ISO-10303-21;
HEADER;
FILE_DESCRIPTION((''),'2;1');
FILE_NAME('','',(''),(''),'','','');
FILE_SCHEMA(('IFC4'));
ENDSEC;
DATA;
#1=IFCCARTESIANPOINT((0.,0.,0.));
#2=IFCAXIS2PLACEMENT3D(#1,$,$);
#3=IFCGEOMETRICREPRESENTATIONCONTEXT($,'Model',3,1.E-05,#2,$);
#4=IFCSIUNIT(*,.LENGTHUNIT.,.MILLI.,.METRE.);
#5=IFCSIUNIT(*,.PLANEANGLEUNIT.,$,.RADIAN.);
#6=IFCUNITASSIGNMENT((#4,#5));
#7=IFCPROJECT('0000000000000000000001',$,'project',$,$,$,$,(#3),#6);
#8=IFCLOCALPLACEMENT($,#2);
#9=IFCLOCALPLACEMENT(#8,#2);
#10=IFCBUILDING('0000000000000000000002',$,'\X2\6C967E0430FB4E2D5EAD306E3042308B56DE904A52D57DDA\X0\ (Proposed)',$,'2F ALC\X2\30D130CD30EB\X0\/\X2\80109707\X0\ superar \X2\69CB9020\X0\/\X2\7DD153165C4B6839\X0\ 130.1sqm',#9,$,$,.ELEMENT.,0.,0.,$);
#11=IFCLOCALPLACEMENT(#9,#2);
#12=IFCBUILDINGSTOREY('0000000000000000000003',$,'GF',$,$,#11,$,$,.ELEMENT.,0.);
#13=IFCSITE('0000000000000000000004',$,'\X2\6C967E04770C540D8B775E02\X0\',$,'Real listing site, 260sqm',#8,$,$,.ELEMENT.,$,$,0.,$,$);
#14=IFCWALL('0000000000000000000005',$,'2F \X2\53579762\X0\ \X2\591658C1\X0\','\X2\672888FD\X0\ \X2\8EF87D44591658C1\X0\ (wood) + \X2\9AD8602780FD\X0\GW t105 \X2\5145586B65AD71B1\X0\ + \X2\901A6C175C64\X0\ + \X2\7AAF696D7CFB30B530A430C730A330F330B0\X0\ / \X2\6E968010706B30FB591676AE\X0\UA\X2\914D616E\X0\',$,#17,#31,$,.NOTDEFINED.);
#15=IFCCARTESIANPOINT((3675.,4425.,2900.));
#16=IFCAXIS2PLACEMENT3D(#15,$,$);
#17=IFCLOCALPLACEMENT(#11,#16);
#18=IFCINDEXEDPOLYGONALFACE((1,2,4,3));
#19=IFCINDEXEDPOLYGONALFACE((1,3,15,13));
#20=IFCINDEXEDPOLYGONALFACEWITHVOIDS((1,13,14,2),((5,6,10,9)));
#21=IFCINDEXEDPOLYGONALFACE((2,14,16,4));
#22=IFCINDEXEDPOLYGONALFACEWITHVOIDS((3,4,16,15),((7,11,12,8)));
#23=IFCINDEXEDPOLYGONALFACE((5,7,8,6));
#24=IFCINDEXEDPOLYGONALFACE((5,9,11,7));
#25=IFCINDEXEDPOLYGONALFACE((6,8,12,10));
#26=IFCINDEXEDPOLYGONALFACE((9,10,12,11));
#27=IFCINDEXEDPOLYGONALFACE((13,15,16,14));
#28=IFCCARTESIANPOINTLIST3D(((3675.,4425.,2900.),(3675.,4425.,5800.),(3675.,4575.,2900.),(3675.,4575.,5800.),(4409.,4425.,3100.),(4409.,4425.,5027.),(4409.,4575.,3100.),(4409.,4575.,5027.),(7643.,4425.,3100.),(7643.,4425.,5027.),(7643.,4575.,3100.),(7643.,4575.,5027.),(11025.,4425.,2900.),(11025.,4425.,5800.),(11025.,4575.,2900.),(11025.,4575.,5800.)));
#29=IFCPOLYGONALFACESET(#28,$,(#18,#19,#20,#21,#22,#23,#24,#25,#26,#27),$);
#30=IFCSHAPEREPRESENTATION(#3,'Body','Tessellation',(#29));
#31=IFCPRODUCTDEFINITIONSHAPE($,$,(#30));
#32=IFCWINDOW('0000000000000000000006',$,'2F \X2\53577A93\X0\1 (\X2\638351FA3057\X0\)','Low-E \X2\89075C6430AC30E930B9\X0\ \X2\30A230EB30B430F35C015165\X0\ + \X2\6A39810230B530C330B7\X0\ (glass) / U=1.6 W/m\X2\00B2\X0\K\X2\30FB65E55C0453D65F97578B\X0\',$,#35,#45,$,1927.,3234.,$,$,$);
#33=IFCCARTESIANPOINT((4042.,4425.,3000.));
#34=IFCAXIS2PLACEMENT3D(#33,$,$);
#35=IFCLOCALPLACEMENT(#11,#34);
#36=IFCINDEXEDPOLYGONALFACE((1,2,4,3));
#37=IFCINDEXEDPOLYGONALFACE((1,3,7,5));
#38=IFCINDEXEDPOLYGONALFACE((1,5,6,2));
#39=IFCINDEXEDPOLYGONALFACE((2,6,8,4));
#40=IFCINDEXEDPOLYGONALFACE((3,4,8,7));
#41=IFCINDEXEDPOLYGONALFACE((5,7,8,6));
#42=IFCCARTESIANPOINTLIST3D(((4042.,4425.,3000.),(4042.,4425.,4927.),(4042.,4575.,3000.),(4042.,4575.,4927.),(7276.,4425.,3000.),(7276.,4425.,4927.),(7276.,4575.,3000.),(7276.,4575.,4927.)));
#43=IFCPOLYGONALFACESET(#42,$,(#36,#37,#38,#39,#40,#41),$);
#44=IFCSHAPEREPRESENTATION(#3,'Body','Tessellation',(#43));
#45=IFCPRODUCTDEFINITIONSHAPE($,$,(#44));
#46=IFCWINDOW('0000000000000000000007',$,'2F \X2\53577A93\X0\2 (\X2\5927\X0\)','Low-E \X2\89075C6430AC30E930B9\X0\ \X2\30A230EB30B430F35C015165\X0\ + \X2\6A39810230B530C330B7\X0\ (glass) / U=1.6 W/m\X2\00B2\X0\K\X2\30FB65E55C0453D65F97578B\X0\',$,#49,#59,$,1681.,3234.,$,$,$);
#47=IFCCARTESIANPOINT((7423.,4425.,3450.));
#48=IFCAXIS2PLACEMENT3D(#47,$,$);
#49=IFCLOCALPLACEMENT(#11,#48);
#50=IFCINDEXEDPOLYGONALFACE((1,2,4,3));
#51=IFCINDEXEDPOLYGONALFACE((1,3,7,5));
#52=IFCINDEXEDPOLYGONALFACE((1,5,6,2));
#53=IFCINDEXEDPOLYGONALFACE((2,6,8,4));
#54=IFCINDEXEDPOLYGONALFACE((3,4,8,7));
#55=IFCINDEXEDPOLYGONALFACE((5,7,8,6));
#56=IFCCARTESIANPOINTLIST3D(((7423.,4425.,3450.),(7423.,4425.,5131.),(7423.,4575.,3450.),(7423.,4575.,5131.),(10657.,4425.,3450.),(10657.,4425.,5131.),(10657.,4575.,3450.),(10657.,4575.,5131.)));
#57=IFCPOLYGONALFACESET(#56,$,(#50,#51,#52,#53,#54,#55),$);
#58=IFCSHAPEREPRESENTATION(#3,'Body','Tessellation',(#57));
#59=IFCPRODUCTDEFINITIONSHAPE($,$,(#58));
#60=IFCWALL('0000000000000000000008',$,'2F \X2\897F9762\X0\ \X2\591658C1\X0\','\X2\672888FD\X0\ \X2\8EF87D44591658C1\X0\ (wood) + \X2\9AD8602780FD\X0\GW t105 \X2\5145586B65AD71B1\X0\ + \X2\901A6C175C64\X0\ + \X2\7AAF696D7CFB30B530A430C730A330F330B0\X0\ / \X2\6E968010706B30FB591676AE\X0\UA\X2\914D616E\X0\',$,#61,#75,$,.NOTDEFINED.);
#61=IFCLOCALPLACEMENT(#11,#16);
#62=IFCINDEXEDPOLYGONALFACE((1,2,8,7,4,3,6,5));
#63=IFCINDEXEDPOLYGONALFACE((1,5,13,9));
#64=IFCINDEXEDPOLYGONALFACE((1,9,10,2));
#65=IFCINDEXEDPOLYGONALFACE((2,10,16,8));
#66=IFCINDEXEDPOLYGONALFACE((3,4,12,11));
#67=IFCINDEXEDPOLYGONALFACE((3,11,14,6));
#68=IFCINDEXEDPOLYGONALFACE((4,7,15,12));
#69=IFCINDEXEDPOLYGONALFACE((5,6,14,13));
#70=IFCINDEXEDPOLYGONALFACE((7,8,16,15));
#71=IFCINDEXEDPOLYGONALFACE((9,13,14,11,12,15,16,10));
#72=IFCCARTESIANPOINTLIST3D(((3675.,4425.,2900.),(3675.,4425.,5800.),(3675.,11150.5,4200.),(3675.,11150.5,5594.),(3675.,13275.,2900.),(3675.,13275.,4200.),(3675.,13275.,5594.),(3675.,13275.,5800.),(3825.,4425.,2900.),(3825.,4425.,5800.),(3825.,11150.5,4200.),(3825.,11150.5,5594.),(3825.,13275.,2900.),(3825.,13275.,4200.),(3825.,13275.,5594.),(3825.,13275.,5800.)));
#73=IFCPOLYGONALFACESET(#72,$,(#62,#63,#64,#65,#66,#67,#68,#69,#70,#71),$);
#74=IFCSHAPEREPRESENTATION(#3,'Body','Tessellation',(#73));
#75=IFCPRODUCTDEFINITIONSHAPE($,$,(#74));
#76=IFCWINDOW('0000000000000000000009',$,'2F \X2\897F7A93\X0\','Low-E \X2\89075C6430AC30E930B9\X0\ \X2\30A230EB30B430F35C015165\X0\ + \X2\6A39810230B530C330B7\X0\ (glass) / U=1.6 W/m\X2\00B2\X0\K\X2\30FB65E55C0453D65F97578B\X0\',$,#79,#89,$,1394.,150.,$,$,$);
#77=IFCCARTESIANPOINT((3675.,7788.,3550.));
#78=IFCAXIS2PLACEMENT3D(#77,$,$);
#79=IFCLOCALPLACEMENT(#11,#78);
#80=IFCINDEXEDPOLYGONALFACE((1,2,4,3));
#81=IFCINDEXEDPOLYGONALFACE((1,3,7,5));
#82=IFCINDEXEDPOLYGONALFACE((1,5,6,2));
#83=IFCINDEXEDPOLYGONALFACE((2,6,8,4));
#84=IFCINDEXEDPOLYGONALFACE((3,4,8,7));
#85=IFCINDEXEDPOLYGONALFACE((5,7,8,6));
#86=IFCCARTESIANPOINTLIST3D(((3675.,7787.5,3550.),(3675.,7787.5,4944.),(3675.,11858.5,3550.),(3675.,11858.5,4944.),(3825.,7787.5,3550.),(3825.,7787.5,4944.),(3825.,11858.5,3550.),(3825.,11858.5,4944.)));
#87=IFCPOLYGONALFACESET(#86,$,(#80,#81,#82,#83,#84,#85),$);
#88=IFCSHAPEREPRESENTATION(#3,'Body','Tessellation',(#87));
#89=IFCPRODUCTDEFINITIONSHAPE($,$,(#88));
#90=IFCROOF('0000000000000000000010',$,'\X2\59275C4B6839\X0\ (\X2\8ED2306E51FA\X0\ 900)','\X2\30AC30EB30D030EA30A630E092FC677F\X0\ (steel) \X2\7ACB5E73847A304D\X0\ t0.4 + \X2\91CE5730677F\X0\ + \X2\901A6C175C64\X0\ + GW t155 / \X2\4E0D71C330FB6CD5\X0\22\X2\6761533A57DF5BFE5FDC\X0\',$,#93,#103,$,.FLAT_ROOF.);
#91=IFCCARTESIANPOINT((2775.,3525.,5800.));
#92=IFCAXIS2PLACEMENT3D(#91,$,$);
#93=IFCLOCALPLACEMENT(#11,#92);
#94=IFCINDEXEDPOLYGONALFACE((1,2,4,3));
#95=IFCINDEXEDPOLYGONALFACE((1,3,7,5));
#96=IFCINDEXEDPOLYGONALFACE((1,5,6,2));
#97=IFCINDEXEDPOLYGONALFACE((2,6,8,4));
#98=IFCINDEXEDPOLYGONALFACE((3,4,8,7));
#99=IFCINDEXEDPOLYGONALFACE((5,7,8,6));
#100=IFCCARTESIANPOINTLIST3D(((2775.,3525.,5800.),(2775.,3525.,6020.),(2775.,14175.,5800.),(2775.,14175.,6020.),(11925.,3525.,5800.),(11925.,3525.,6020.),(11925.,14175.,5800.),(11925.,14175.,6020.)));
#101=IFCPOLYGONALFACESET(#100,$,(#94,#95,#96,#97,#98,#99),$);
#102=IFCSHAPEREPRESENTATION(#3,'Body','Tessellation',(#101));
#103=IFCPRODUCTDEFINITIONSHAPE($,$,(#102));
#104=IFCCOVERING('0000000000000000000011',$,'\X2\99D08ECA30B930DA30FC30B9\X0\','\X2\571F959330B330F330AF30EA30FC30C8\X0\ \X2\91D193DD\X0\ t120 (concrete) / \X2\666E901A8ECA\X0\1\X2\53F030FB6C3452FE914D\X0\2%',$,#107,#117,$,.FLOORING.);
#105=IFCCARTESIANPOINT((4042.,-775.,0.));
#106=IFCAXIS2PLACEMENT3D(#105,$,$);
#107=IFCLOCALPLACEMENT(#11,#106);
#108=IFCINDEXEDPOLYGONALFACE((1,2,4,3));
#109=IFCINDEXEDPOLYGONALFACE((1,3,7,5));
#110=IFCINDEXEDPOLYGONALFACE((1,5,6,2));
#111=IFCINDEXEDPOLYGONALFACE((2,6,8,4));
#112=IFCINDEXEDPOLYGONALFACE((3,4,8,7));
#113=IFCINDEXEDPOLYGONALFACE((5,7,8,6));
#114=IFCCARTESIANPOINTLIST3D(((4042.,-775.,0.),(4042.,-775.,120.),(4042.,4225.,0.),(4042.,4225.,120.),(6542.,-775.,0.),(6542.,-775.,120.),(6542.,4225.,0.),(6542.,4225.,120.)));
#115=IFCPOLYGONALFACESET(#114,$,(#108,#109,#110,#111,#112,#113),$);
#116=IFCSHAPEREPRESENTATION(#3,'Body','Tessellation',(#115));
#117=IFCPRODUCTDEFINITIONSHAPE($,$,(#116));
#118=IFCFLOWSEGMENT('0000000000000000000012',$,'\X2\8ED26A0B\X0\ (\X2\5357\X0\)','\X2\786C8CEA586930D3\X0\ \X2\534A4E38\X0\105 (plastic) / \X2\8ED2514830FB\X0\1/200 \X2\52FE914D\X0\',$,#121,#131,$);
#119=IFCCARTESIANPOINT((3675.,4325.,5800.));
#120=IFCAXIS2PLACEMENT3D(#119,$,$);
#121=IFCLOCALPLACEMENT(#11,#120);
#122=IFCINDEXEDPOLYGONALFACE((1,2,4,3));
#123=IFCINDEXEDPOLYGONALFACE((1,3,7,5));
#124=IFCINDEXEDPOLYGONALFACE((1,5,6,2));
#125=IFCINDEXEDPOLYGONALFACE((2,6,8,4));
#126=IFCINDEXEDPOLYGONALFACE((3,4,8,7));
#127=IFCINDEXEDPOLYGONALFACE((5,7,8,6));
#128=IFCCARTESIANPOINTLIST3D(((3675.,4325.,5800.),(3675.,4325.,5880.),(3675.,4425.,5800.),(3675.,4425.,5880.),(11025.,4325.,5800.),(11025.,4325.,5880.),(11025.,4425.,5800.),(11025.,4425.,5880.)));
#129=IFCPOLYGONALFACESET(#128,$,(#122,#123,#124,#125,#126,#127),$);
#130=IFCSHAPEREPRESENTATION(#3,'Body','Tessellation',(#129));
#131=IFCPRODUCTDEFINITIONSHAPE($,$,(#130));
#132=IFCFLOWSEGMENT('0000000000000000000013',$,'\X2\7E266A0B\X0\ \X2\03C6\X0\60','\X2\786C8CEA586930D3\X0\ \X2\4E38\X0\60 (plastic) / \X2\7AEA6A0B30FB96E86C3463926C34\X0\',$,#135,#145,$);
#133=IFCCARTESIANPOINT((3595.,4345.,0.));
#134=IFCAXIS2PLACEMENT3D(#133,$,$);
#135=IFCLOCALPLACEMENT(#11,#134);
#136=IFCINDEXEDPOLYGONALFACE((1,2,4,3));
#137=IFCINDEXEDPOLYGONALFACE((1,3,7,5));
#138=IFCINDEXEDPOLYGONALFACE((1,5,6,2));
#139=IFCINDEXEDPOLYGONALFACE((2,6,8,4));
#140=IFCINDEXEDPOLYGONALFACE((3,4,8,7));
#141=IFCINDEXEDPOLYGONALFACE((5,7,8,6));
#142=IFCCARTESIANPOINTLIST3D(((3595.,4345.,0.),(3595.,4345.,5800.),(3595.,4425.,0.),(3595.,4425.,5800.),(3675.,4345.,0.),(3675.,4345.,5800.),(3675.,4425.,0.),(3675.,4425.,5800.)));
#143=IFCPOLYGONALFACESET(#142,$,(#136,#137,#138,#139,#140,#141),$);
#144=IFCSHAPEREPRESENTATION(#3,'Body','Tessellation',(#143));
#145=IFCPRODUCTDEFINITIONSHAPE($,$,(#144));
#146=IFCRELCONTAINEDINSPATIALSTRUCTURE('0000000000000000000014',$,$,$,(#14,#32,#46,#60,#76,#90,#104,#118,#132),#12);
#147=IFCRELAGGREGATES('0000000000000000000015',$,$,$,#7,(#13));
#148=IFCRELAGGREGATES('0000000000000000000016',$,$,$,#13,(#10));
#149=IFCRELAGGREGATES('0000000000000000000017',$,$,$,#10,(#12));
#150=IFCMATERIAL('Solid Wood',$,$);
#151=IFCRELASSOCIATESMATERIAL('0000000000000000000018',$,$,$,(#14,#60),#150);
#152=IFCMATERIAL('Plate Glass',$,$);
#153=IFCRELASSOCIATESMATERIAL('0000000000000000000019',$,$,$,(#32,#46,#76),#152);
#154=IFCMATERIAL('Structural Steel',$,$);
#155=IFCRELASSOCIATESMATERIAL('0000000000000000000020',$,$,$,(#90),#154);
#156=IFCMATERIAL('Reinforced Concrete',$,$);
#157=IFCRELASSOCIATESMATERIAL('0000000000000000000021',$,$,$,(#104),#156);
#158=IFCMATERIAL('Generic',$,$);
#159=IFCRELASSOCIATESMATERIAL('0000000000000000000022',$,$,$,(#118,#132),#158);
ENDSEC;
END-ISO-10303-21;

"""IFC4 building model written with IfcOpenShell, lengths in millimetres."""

from ifc_helpers import new_model, si_unit, frame, frame_2d, origin, place, context, project, spatial, rectangle, extrude, material, element, fill, save


model = new_model("IFC4")

# Units and contexts
model_context = context("Model", 3, precision=1e-05, world=origin())
ifc_project = project(units=[si_unit("LENGTHUNIT", "METRE", prefix="MILLI"), si_unit("PLANEANGLEUNIT", "RADIAN")], contexts=[model_context])

# Site, building, storey
site_placement = place(None, origin())
site = spatial("IfcSite", under=ifc_project, at=site_placement, Name="沖縄県名護市", ObjectType="Real listing site, 260sqm", CompositionType="ELEMENT", RefElevation=0.0)
building_placement = place(site_placement, origin())
building = spatial("IfcBuilding", under=site, at=building_placement, Name="沖縄・中庭のある回遊動線 (Proposed)", ObjectType="2F ALCパネル/耐震 superar 構造/緑化屋根 130.1sqm", CompositionType="ELEMENT", ElevationOfRefHeight=0.0, ElevationOfTerrain=0.0)
storey_placement = place(building_placement, origin())
storey = spatial("IfcBuildingStorey", under=building, at=storey_placement, Name="GF", CompositionType="ELEMENT", Elevation=0.0)

# Shared definitions
ifc_material_1 = material(Name="Solid Wood")

# Shared definitions
ifc_material_2 = material(Name="Reinforced Concrete")

# Shared definitions
ifc_material_3 = material(Name="Plate Glass")

# Wall, openings, windows
wall_1_placement = place(storey_placement, frame((3675.0, 4425.0, 2900.0)))
wall_1 = element("IfcWall", 1, at=wall_1_placement, inside=storey, material=ifc_material_1, Name="2F 南面 外壁", Description="木製 軸組外壁 (wood) + 高性能GW t105 充填断熱 + 通気層 + 窯業系サイディング / 準耐火・外皮UA配慮", PredefinedType="NOTDEFINED", context=model_context, shape_type="SweptSolid", body=[
    extrude(rectangle(XDim=7350.0, YDim=150.0, at=frame_2d((3675.0, 75.0))), frame((3675.0, 4425.0, 2900.0)), (0.0, 0.0, 1.0), 2900.0),
])
opening_1_placement = place(storey_placement, frame((4042.0, 4425.0, 3000.0)))
opening_1 = element("IfcOpeningElement", 2, at=opening_1_placement, cuts=wall_1, PredefinedType="NOTDEFINED", context=model_context, shape_type="SweptSolid", body=[
    extrude(rectangle(XDim=3234.0, YDim=150.0, at=frame_2d((1617.0, 75.0))), frame((4042.0, 4425.0, 3000.0)), (0.0, 0.0, 1.0), 1927.0),
])
opening_2_placement = place(storey_placement, frame((7423.0, 4425.0, 3450.0)))
opening_2 = element("IfcOpeningElement", 3, at=opening_2_placement, cuts=wall_1, PredefinedType="NOTDEFINED", context=model_context, shape_type="SweptSolid", body=[
    extrude(rectangle(XDim=3234.0, YDim=150.0, at=frame_2d((1617.0, 75.0))), frame((7423.0, 4425.0, 3450.0)), (0.0, 0.0, 1.0), 1681.0),
])
window_1_placement = place(storey_placement, frame((4042.0, 4425.0, 3000.0)))
window_1 = element("IfcWindow", 4, at=window_1_placement, inside=storey, material=ifc_material_3, Name="2F 南窓1 (掃出し)", Description="Low-E 複層ガラス アルゴン封入 + 樹脂サッシ (glass) / U=1.6 W/m²K・日射取得型", OverallHeight=1927.0, OverallWidth=3234.0, context=model_context, shape_type="SweptSolid", body=[
    extrude(rectangle(XDim=3234.0, YDim=150.0, at=frame_2d((1617.0, 75.0))), frame((4042.0, 4425.0, 3000.0)), (0.0, 0.0, 1.0), 1927.0),
])
fill(opening_1, window_1)
window_2_placement = place(storey_placement, frame((7423.0, 4425.0, 3450.0)))
window_2 = element("IfcWindow", 5, at=window_2_placement, inside=storey, material=ifc_material_3, Name="2F 南窓2 (大)", Description="Low-E 複層ガラス アルゴン封入 + 樹脂サッシ (glass) / U=1.6 W/m²K・日射取得型", OverallHeight=1681.0, OverallWidth=3234.0, context=model_context, shape_type="SweptSolid", body=[
    extrude(rectangle(XDim=3234.0, YDim=150.0, at=frame_2d((1617.0, 75.0))), frame((7423.0, 4425.0, 3450.0)), (0.0, 0.0, 1.0), 1681.0),
])
fill(opening_2, window_2)

# Wall, opening, window
wall_2_placement = place(storey_placement, frame((3675.0, 4425.0, 2900.0)))
wall_2 = element("IfcWall", 6, at=wall_2_placement, inside=storey, material=ifc_material_1, Name="2F 西面 外壁", Description="木製 軸組外壁 (wood) + 高性能GW t105 充填断熱 + 通気層 + 窯業系サイディング / 準耐火・外皮UA配慮", PredefinedType="NOTDEFINED", context=model_context, shape_type="SweptSolid", body=[
    extrude(rectangle(XDim=150.0, YDim=8850.0, at=frame_2d((75.0, 4425.0))), frame((3675.0, 4425.0, 2900.0)), (0.0, 0.0, 1.0), 2900.0),
])
opening_3_placement = place(storey_placement, frame((3675.0, 7788.0, 3550.0)))
opening_3 = element("IfcOpeningElement", 7, at=opening_3_placement, cuts=wall_2, PredefinedType="NOTDEFINED", context=model_context, shape_type="SweptSolid", body=[
    extrude(rectangle(XDim=150.0, YDim=4071.0, at=frame_2d((75.0, 2035.0))), frame((3675.0, 7788.0, 3550.0)), (0.0, 0.0, 1.0), 1394.0),
])
window_3_placement = place(storey_placement, frame((3675.0, 7788.0, 3550.0)))
window_3 = element("IfcWindow", 8, at=window_3_placement, inside=storey, material=ifc_material_3, Name="2F 西窓", Description="Low-E 複層ガラス アルゴン封入 + 樹脂サッシ (glass) / U=1.6 W/m²K・日射取得型", OverallHeight=1394.0, OverallWidth=150.0, context=model_context, shape_type="SweptSolid", body=[
    extrude(rectangle(XDim=150.0, YDim=4071.0, at=frame_2d((75.0, 2035.0))), frame((3675.0, 7788.0, 3550.0)), (0.0, 0.0, 1.0), 1394.0),
])
fill(opening_3, window_3)

# Roof
ifc_material_4 = material(Name="Structural Steel")
roof_placement = place(storey_placement, frame((2775.0, 3525.0, 5800.0)))
element("IfcRoof", 9, at=roof_placement, inside=storey, material=ifc_material_4, Name="大屋根 (軒の出 900)", Description="ガルバリウム鋼板 (steel) 立平葺き t0.4 + 野地板 + 通気層 + GW t155 / 不燃・法22条区域対応", PredefinedType="FLAT_ROOF", context=model_context, shape_type="SweptSolid", body=[
    extrude(rectangle(XDim=9150.0, YDim=10650.0, at=frame_2d((4575.0, 5325.0))), frame((2775.0, 3525.0, 5800.0)), (0.0, 0.0, 1.0), 220.0),
])

# Covering
covering_placement = place(storey_placement, frame((4042.0, -775.0, 0.0)))
element("IfcCovering", 10, at=covering_placement, inside=storey, material=ifc_material_2, Name="駐車スペース", Description="土間コンクリート 金鏝 t120 (concrete) / 普通車1台・水勾配2%", PredefinedType="FLOORING", context=model_context, shape_type="SweptSolid", body=[
    extrude(rectangle(XDim=2500.0, YDim=5000.0, at=frame_2d((1250.0, 2500.0))), frame((4042.0, -775.0, 0.0)), (0.0, 0.0, 1.0), 120.0),
])

# Flow segments
ifc_material_5 = material(Name="Generic")
flow_segment_1_placement = place(storey_placement, frame((3675.0, 4325.0, 5800.0)))
element("IfcFlowSegment", 11, at=flow_segment_1_placement, inside=storey, material=ifc_material_5, Name="軒樋 (南)", Description="硬質塩ビ 半丸105 (plastic) / 軒先・1/200 勾配", context=model_context, shape_type="SweptSolid", body=[
    extrude(rectangle(XDim=7350.0, YDim=100.0, at=frame_2d((3675.0, 50.0))), frame((3675.0, 4325.0, 5800.0)), (0.0, 0.0, 1.0), 80.0),
])
flow_segment_2_placement = place(storey_placement, frame((3595.0, 4345.0, 0.0)))
element("IfcFlowSegment", 12, at=flow_segment_2_placement, inside=storey, material=ifc_material_5, Name="縦樋 φ60", Description="硬質塩ビ 丸60 (plastic) / 竪樋・雨水排水", context=model_context, shape_type="SweptSolid", body=[
    extrude(rectangle(XDim=80.0, YDim=80.0, at=frame_2d((40.0, 40.0))), frame((3595.0, 4345.0, 0.0)), (0.0, 0.0, 1.0), 5800.0),
])

save(model, "model.ifc")
